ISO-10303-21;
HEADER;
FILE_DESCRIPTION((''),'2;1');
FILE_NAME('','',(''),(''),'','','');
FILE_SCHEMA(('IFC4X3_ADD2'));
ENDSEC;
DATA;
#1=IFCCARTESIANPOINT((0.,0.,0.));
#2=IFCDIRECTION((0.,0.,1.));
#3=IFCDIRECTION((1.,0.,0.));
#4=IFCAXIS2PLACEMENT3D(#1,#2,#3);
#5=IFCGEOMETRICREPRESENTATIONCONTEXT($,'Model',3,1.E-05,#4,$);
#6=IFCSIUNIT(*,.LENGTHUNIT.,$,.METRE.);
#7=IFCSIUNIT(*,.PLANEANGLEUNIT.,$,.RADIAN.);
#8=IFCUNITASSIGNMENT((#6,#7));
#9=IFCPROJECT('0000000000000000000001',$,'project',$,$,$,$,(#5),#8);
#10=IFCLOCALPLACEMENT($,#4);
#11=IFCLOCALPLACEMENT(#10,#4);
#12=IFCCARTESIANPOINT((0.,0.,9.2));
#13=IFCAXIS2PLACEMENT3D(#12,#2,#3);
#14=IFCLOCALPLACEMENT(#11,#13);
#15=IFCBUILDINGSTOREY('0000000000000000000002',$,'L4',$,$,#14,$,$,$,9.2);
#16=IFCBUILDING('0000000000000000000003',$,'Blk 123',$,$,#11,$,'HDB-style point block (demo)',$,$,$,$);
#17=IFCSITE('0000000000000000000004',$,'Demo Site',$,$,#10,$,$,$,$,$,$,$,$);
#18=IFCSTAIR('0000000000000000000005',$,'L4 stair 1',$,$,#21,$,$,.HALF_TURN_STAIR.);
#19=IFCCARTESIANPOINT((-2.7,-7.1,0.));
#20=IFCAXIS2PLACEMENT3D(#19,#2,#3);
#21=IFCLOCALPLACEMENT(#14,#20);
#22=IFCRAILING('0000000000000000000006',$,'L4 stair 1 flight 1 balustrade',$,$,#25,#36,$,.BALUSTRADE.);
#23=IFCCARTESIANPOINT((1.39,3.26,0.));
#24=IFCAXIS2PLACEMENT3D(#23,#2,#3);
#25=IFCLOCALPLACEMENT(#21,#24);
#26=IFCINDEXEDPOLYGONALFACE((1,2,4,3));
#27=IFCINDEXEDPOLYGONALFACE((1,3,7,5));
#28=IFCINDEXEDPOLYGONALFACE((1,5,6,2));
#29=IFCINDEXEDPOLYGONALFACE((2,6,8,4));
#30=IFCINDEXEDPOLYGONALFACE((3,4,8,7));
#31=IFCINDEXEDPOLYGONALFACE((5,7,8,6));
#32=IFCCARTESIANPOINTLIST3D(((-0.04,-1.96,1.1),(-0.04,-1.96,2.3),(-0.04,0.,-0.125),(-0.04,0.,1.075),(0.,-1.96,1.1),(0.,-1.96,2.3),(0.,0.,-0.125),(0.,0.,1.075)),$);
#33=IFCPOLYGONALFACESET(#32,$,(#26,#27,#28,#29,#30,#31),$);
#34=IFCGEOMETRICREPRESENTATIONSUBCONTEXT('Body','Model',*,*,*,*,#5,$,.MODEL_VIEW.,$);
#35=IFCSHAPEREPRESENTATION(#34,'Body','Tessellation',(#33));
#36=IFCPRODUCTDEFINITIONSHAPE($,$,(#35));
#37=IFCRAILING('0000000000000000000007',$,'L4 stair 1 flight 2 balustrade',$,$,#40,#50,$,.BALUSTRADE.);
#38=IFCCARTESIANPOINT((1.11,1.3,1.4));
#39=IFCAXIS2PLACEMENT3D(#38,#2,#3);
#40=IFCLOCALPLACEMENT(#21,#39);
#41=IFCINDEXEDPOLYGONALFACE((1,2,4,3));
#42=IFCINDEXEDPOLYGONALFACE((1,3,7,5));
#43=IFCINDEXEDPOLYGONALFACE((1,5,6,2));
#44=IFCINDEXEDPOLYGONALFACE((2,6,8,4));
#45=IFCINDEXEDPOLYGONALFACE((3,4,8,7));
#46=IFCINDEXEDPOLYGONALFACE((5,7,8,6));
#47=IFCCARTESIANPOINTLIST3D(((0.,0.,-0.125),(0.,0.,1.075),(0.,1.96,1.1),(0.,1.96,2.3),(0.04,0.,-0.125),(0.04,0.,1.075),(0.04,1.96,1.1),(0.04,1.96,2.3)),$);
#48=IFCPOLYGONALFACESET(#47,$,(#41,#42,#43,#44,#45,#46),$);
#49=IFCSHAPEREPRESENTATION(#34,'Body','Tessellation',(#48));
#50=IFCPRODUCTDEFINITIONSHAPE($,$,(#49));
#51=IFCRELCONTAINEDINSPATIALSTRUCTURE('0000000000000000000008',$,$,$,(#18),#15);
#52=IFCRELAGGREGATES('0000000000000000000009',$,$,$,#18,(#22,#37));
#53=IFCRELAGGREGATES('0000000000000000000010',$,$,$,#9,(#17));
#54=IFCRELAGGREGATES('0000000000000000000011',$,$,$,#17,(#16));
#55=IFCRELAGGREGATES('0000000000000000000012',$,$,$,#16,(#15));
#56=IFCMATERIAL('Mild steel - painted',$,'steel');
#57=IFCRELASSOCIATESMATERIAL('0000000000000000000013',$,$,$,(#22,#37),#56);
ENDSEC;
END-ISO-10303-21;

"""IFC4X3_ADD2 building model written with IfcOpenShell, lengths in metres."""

from ifc_helpers import new_model, si_unit, frame, origin_with_axes, place, context, subcontext, project, spatial, polyline, outline, extrude, material, element, aggregate, save


model = new_model("IFC4X3_ADD2")

# Units and contexts
model_context = context("Model", 3, precision=1e-05, world=origin_with_axes())
body_context = subcontext(model_context, "Body", "Model", "MODEL_VIEW")
ifc_project = project(units=[si_unit("LENGTHUNIT", "METRE"), si_unit("PLANEANGLEUNIT", "RADIAN")], contexts=[model_context])

# Site, building, storey
site_placement = place(None, origin_with_axes())
site = spatial("IfcSite", under=ifc_project, at=site_placement, Name="Demo Site")
building_placement = place(site_placement, origin_with_axes())
building = spatial("IfcBuilding", under=site, at=building_placement, Name="Blk 123", LongName="HDB-style point block (demo)")
storey_placement = place(building_placement, frame((0.0, 0.0, 9.2), z_axis=(0.0, 0.0, 1.0), x_axis=(1.0, 0.0, 0.0)))
storey = spatial("IfcBuildingStorey", under=building, at=storey_placement, Name="L4", Elevation=9.2)

# Stair
stair_placement = place(storey_placement, frame((-2.7, -7.1, 0.0), z_axis=(0.0, 0.0, 1.0), x_axis=(1.0, 0.0, 0.0)))
stair = element("IfcStair", 1, at=stair_placement, inside=storey, Name="L4 stair 1", PredefinedType="HALF_TURN_STAIR")

# Railings
ifc_material_1 = material(Name="Mild steel - painted", Category="steel")
railing_1_placement = place(stair_placement, frame((1.39, 3.26, 0.0), z_axis=(0.0, 0.0, 1.0), x_axis=(1.0, 0.0, 0.0)))
railing_1 = element("IfcRailing", 2, at=railing_1_placement, material=ifc_material_1, Name="L4 stair 1 flight 1 balustrade", PredefinedType="BALUSTRADE", context=body_context, shape_type="SweptSolid", body=[
    extrude(outline(polyline([(0.0, -0.125), (1.96, 1.1), (1.96, 2.3), (0.0, 1.075), (0.0, -0.125)])), frame((0.0, 0.0, 0.0), z_axis=(-1.0, 0.0, 0.0), x_axis=(0.0, -1.0, 0.0)), (0.0, 0.0, 1.0), 0.04),
])
railing_2_placement = place(stair_placement, frame((1.11, 1.3, 1.4), z_axis=(0.0, 0.0, 1.0), x_axis=(1.0, 0.0, 0.0)))
railing_2 = element("IfcRailing", 3, at=railing_2_placement, material=ifc_material_1, Name="L4 stair 1 flight 2 balustrade", PredefinedType="BALUSTRADE", context=body_context, shape_type="SweptSolid", body=[
    extrude(outline(polyline([(0.0, -0.125), (1.96, 1.1), (1.96, 2.3), (0.0, 1.075), (0.0, -0.125)])), frame((0.0, 0.0, 0.0), z_axis=(1.0, 0.0, 0.0), x_axis=(0.0, 1.0, 0.0)), (0.0, 0.0, 1.0), 0.04),
])
aggregate(stair, [railing_1, railing_2])

save(model, "model.ifc")
